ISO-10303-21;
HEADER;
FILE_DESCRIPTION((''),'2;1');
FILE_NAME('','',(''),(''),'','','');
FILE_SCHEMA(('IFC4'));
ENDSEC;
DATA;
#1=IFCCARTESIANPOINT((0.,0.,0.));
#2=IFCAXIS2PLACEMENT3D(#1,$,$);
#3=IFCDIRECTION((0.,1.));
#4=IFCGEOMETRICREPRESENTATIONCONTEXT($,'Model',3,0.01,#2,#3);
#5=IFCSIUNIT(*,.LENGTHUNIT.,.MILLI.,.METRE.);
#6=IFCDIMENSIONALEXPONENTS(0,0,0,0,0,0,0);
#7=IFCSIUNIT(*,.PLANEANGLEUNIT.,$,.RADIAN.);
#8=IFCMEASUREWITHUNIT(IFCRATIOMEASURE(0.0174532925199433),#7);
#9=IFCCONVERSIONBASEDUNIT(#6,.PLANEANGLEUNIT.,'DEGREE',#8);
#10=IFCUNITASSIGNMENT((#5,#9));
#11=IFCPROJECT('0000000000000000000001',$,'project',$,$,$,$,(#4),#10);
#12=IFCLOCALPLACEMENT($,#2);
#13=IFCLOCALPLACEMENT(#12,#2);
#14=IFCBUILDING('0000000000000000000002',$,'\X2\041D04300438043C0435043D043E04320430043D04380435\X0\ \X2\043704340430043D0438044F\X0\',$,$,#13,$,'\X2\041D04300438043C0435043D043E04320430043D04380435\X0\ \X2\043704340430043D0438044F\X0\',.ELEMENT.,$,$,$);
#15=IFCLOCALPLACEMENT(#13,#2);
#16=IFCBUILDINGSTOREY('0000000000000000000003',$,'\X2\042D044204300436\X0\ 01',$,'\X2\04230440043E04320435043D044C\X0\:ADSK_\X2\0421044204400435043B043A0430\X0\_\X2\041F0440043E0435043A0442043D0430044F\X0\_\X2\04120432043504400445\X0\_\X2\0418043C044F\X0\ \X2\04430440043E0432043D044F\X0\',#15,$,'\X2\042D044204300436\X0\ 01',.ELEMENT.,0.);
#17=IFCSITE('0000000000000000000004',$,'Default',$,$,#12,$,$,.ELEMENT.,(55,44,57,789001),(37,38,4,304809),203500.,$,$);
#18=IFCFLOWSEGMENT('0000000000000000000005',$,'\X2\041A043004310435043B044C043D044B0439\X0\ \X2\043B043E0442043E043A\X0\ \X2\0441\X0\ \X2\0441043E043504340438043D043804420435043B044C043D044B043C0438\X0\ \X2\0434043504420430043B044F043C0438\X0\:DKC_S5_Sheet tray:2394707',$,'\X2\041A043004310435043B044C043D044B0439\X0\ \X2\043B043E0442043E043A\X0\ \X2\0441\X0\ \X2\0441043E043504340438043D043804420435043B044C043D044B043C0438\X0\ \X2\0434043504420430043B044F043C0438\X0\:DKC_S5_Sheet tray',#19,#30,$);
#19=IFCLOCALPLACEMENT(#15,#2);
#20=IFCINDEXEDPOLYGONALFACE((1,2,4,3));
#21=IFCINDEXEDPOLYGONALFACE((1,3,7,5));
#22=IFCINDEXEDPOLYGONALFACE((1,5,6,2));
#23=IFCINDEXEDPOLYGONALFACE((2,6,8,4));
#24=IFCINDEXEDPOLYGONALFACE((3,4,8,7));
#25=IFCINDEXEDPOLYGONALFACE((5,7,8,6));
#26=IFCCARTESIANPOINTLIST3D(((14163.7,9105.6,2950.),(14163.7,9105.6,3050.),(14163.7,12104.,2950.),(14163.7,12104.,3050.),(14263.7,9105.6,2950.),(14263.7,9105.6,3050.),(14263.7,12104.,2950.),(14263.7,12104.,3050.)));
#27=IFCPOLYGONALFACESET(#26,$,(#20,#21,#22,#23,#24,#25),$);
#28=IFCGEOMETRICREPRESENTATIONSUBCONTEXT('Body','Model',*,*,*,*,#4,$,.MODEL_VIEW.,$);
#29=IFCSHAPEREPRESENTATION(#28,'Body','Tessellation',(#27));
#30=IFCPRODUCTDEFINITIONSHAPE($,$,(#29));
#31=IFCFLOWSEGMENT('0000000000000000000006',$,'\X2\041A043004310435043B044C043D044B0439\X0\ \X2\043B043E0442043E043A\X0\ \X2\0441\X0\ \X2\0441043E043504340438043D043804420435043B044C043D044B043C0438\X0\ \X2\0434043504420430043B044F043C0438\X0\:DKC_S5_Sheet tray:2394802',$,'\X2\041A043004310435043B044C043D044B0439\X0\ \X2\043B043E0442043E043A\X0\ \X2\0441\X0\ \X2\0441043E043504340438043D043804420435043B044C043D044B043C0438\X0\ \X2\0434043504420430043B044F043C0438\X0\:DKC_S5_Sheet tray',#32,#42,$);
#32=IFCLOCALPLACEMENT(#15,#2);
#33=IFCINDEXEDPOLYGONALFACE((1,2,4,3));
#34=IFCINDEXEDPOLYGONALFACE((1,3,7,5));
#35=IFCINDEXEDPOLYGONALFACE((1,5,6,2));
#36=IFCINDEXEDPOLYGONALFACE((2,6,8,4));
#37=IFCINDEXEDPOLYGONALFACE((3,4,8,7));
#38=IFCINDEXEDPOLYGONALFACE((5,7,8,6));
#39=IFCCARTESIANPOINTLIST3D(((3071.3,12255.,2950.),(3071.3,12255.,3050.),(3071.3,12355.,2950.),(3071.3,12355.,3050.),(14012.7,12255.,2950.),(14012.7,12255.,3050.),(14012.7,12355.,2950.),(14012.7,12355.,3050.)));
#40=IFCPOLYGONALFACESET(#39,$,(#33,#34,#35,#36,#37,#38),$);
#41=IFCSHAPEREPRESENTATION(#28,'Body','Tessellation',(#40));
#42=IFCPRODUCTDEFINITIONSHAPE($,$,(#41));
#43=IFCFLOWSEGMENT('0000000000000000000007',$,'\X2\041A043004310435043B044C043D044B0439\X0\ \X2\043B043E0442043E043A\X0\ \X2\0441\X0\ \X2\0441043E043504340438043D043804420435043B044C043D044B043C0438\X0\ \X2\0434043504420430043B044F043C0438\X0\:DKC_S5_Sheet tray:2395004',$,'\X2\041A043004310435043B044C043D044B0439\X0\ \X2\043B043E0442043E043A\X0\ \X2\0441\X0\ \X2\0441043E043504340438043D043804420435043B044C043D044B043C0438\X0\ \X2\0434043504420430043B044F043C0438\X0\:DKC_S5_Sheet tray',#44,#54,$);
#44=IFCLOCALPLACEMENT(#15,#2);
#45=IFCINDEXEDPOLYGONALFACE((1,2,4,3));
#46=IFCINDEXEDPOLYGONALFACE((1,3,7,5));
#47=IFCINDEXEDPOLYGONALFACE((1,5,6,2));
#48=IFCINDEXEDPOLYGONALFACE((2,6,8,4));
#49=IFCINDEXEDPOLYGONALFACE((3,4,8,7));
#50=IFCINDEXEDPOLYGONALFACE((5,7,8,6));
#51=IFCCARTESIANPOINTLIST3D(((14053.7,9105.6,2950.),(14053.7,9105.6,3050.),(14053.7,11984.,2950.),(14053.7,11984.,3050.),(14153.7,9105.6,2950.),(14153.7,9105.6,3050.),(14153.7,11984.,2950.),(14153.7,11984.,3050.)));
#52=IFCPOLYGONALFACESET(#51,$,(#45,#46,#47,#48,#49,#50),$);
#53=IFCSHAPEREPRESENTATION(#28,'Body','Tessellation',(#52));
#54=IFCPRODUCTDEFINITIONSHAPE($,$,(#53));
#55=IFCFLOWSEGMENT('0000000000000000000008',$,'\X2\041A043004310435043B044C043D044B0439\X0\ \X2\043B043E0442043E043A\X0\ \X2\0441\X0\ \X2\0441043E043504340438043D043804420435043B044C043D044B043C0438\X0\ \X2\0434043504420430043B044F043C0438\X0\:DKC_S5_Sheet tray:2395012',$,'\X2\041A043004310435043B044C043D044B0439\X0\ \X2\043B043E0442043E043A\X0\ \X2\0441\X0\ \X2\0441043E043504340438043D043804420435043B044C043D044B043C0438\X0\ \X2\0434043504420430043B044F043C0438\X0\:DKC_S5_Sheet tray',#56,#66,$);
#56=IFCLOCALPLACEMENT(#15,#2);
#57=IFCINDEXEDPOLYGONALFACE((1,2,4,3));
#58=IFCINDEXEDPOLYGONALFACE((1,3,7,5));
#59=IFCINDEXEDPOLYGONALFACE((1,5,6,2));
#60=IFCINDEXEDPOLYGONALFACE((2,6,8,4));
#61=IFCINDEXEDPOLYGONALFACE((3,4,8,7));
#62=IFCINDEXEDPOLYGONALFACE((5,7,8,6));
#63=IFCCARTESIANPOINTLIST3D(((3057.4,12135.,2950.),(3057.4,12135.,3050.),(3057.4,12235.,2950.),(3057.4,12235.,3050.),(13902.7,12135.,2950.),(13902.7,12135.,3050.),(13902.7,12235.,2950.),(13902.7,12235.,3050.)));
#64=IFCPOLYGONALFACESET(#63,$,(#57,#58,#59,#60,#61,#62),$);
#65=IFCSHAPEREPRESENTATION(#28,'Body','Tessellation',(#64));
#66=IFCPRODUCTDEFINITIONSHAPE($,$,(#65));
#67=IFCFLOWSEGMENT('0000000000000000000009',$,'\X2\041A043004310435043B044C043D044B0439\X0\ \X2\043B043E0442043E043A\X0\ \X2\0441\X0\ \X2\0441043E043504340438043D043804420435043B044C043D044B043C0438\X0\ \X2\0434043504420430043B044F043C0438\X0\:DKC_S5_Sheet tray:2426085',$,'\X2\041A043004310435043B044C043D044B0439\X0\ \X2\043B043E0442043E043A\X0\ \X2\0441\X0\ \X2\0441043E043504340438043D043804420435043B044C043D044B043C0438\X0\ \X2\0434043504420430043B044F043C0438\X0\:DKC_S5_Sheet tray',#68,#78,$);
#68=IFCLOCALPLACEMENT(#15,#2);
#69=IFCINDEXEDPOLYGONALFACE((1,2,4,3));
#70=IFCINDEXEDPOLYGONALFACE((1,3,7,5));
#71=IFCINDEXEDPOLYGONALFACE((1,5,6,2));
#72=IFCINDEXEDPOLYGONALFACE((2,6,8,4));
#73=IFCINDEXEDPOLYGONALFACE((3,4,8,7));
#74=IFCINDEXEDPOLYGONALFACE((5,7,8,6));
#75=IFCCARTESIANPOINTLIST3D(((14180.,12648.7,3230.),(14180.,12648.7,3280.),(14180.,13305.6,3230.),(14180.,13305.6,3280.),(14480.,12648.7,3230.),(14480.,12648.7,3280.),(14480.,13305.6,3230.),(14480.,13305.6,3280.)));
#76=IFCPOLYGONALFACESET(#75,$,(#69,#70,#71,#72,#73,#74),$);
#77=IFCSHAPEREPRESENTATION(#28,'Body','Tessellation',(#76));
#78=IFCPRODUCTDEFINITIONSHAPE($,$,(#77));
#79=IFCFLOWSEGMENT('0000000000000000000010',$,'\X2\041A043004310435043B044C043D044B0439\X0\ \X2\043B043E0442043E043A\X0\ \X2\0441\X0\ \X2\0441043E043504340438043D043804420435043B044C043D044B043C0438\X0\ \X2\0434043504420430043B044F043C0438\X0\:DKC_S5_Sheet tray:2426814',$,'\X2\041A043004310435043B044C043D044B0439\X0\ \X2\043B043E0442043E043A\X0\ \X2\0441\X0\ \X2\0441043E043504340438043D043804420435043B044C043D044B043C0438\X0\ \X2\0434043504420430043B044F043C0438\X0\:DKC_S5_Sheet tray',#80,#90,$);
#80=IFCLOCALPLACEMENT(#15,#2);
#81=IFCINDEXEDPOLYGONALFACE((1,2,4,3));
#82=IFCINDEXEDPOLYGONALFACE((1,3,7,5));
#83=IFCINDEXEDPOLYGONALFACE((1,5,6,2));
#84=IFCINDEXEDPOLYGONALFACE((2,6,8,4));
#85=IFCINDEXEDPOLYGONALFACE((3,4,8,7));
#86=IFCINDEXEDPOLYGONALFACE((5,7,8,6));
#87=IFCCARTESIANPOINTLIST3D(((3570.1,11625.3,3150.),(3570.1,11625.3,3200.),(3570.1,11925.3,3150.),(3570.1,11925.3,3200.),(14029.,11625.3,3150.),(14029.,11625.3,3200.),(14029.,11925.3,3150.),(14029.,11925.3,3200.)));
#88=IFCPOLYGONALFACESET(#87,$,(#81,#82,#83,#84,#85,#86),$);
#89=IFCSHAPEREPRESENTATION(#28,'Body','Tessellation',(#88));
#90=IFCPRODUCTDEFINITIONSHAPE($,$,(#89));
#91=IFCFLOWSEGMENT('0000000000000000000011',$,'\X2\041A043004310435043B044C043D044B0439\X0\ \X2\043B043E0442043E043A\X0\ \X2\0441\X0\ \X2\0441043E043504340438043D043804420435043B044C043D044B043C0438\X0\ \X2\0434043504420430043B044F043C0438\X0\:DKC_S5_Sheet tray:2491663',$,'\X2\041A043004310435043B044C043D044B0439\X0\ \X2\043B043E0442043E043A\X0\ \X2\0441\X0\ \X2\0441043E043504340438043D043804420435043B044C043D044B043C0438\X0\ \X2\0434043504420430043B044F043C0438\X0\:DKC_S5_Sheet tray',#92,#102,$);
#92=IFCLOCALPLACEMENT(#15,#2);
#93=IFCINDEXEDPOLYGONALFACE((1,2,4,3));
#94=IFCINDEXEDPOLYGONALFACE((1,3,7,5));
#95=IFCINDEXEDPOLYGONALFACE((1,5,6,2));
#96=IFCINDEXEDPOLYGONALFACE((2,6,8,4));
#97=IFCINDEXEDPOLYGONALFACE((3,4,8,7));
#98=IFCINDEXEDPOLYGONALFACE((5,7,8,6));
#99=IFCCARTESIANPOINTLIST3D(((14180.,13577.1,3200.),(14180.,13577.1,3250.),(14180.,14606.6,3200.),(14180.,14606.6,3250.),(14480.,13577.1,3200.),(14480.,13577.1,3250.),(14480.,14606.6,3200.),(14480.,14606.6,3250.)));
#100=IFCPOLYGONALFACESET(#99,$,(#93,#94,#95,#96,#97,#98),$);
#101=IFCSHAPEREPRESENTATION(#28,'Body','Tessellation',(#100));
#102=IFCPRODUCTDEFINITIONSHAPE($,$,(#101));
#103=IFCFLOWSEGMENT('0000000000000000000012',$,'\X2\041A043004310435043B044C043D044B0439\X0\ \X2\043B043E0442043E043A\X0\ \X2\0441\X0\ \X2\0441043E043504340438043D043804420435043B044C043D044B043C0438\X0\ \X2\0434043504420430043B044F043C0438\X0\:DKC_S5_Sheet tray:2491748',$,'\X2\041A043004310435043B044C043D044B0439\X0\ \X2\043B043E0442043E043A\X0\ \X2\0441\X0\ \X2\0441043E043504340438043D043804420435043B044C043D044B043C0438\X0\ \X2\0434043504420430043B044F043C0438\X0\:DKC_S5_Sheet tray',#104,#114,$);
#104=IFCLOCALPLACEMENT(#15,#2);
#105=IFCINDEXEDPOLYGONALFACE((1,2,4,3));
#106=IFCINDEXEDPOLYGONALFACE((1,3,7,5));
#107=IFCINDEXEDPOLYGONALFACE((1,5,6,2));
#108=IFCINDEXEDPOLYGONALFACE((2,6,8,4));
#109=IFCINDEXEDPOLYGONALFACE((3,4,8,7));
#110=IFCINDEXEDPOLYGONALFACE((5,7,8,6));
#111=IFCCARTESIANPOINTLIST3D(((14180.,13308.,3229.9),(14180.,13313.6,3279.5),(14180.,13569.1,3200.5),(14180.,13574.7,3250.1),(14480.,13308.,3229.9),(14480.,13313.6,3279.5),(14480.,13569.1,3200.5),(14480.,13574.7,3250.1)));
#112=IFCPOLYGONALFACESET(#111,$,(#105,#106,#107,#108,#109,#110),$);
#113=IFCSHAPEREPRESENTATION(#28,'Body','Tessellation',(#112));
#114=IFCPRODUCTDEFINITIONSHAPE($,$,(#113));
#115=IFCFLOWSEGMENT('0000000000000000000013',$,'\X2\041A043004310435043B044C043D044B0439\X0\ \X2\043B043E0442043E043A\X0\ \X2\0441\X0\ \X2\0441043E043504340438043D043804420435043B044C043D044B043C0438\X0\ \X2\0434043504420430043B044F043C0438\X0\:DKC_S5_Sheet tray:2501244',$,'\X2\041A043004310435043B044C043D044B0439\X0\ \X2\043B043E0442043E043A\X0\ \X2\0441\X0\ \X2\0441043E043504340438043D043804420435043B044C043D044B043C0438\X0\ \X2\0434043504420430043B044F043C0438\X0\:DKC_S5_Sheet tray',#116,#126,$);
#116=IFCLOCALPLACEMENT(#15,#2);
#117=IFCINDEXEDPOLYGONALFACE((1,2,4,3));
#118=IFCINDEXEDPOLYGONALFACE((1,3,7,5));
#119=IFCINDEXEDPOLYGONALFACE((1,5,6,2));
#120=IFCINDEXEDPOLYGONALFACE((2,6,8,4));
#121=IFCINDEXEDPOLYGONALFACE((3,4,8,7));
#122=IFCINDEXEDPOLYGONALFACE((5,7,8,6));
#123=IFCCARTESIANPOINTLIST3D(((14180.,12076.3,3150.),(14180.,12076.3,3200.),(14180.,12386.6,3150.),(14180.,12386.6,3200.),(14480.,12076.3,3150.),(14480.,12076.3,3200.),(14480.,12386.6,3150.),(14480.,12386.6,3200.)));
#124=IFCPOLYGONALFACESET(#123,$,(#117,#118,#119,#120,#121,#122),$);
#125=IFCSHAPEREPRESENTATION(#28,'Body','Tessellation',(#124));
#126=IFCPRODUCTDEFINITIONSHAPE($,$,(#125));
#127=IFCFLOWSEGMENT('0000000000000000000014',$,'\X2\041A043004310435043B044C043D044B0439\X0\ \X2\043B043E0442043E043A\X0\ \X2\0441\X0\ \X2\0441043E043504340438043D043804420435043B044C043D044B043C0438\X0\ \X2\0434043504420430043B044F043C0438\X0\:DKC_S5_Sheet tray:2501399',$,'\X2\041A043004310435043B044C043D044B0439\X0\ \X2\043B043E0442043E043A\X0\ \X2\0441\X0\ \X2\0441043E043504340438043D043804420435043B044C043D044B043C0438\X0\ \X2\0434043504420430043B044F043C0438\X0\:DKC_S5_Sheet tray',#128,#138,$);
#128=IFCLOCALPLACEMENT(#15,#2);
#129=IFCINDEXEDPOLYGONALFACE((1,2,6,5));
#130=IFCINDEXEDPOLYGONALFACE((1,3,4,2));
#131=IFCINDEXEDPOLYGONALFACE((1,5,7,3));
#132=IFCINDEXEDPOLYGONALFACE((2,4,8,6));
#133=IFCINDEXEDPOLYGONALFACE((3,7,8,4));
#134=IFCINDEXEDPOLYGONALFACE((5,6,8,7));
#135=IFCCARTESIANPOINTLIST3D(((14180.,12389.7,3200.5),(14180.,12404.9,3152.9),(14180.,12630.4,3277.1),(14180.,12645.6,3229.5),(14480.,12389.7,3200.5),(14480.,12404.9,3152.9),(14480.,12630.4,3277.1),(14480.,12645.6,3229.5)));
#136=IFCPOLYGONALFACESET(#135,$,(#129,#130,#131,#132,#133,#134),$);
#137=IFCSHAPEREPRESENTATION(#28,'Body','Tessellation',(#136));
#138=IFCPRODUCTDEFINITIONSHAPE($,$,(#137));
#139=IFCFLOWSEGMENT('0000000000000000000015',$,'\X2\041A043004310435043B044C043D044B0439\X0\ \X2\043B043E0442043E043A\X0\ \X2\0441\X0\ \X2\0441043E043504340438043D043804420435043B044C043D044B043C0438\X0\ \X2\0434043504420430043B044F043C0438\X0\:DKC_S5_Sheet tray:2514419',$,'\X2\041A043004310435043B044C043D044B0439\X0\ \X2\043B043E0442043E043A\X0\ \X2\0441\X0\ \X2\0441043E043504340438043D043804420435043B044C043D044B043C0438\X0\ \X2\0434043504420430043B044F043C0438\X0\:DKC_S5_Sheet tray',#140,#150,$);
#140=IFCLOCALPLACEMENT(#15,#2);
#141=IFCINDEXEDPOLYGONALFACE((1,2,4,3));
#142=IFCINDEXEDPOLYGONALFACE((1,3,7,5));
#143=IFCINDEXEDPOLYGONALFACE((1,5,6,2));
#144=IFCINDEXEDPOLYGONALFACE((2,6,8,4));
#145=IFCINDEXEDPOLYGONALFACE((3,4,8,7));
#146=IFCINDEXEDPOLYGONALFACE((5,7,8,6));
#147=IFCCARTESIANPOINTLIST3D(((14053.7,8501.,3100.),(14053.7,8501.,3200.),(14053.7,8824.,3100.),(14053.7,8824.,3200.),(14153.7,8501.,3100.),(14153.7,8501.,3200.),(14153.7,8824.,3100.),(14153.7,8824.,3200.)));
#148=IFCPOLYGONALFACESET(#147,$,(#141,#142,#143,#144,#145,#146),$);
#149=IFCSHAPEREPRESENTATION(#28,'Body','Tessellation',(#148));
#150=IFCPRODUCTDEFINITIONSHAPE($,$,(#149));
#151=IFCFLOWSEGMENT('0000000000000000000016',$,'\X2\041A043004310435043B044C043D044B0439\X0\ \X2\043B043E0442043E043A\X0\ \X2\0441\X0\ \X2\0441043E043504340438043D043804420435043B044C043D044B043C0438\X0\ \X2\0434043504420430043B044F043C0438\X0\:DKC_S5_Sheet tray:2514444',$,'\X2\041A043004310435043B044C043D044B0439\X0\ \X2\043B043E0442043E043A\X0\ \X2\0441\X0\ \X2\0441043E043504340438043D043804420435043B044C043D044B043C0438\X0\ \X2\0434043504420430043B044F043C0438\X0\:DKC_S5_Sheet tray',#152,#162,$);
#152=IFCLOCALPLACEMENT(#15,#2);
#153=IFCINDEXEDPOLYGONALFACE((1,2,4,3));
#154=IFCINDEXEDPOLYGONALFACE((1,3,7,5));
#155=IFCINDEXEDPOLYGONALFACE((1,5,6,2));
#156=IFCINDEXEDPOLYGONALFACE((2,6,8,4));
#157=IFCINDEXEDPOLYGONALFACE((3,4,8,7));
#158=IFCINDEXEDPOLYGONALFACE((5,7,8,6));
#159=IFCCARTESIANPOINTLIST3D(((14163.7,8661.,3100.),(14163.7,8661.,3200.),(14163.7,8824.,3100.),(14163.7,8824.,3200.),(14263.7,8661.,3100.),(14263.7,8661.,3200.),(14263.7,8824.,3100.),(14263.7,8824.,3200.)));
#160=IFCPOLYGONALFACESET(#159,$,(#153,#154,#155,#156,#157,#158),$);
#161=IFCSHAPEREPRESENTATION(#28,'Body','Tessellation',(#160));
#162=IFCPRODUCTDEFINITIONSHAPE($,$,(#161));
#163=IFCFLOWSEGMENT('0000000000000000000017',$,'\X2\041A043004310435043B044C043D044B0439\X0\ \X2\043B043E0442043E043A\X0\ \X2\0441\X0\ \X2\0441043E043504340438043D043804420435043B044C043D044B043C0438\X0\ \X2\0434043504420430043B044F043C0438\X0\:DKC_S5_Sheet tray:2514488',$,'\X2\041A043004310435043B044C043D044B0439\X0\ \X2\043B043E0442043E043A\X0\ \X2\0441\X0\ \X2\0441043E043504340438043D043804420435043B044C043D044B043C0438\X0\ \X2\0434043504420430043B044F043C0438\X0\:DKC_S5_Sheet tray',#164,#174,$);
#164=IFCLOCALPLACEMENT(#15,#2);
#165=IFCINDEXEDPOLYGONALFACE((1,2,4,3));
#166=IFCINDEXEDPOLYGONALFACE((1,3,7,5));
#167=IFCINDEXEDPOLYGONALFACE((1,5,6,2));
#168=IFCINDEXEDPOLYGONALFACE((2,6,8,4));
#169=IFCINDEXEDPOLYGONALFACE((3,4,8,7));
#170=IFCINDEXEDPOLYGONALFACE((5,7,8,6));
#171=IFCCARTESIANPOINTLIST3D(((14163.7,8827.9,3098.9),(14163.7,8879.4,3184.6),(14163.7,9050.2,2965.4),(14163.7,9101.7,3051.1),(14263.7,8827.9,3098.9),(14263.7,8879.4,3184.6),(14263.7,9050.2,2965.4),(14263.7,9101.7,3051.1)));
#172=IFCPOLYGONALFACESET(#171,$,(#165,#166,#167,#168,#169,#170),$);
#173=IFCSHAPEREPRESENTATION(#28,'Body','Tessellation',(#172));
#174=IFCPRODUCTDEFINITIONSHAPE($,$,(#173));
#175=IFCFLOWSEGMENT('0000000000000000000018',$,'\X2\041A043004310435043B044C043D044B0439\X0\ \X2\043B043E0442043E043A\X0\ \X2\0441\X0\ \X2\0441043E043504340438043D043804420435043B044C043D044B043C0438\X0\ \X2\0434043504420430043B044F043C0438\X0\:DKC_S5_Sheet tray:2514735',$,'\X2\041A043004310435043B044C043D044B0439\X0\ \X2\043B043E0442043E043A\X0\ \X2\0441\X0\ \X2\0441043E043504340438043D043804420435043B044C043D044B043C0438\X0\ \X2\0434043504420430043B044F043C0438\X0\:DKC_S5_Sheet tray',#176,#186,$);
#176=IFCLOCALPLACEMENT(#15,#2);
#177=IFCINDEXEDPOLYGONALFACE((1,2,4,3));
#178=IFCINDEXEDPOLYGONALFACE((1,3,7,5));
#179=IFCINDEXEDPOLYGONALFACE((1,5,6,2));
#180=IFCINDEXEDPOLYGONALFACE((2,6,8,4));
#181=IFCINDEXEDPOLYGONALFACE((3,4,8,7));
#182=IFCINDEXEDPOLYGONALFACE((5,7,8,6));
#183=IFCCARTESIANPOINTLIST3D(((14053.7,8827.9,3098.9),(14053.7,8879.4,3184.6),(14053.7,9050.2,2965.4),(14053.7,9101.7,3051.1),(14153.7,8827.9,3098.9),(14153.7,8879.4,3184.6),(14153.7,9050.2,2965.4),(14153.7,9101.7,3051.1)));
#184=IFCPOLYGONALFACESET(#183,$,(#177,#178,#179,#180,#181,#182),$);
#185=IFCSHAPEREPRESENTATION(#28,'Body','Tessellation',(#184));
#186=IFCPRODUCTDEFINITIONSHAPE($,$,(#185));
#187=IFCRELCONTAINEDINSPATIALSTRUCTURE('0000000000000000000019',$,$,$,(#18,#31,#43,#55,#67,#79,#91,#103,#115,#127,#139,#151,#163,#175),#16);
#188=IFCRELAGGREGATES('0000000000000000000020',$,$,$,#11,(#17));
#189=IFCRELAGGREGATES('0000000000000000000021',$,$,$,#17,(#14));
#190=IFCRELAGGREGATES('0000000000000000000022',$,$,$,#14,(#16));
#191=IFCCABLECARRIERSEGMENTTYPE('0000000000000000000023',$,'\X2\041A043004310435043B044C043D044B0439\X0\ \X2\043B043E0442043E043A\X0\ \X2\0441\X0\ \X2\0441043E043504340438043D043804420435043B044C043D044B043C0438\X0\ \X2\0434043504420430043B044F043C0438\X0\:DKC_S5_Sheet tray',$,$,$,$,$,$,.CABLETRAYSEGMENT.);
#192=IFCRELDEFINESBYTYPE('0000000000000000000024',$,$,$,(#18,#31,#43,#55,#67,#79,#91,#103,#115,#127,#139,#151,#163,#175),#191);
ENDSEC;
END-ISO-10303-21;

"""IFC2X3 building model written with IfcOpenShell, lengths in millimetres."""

from ifc_helpers import new_model, entity, si_unit, converted_unit, direction, frame, frame_2d, origin, origin_2d_with_axis, place, context, subcontext, project, spatial, rectangle, extrude, type_object, element, save


model = new_model("IFC2X3")

# Units and contexts
model_context = context("Model", 3, precision=0.01, world=origin(), true_north=direction((0.0, 1.0)))
body_context = subcontext(model_context, "Body", "Model", "MODEL_VIEW")
ifc_project = project(units=[si_unit("LENGTHUNIT", "METRE", prefix="MILLI"), converted_unit("PLANEANGLEUNIT", "DEGREE", entity("IfcRatioMeasure", 0.0174532925199433), si_unit("PLANEANGLEUNIT", "RADIAN"), dimensions=[0, 0, 0, 0, 0, 0, 0])], contexts=[model_context])

# Site, building, storey
site_placement = place(None, origin())
site = spatial("IfcSite", under=ifc_project, at=site_placement, Name="Default", CompositionType="ELEMENT", RefLatitude=(55, 44, 57, 789001), RefLongitude=(37, 38, 4, 304809), RefElevation=203500.0)
building_placement = place(site_placement, origin())
building = spatial("IfcBuilding", under=site, at=building_placement, Name="Наименование здания", LongName="Наименование здания", CompositionType="ELEMENT")
storey_placement = place(building_placement, origin())
storey = spatial("IfcBuildingStorey", under=building, at=storey_placement, Name="Этаж 01", ObjectType="Уровень:ADSK_Стрелка_Проектная_Вверх_Имя уровня", LongName="Этаж 01", CompositionType="ELEMENT", Elevation=0.0)

# Flow segments
cable_carrier_segment_type = type_object("IfcCableCarrierSegmentType", Name="Кабельный лоток с соединительными деталями:DKC_S5_Sheet tray", PredefinedType="CABLETRAYSEGMENT")
flow_segment_1_placement = place(storey_placement, frame((14163.7, 9105.6, 2950.0)))
element("IfcFlowSegment", 1, at=flow_segment_1_placement, inside=storey, type_object=cable_carrier_segment_type, Name="Кабельный лоток с соединительными деталями:DKC_S5_Sheet tray:2394707", ObjectType="Кабельный лоток с соединительными деталями:DKC_S5_Sheet tray", context=body_context, shape_type="SweptSolid", body=[
    extrude(rectangle(XDim=2998.4, YDim=100.0, at=origin_2d_with_axis()), frame((50.0, 1499.2, 0.0), z_axis=(0.0, 0.0, 1.0), x_axis=(0.0, -1.0, 0.0)), (0.0, 0.0, 1.0), 100.0),
])
flow_segment_2_placement = place(storey_placement, frame((3071.3, 12255.0, 2950.0)))
element("IfcFlowSegment", 2, at=flow_segment_2_placement, inside=storey, type_object=cable_carrier_segment_type, Name="Кабельный лоток с соединительными деталями:DKC_S5_Sheet tray:2394802", ObjectType="Кабельный лоток с соединительными деталями:DKC_S5_Sheet tray", context=body_context, shape_type="SweptSolid", body=[
    extrude(rectangle(XDim=10941.4, YDim=100.0, at=origin_2d_with_axis()), frame((5470.7, 50.0, 0.0), z_axis=(0.0, 0.0, 1.0), x_axis=(-1.0, 0.0, 0.0)), (0.0, 0.0, 1.0), 100.0),
])
flow_segment_3_placement = place(storey_placement, frame((14053.7, 9105.6, 2950.0)))
element("IfcFlowSegment", 3, at=flow_segment_3_placement, inside=storey, type_object=cable_carrier_segment_type, Name="Кабельный лоток с соединительными деталями:DKC_S5_Sheet tray:2395004", ObjectType="Кабельный лоток с соединительными деталями:DKC_S5_Sheet tray", context=body_context, shape_type="SweptSolid", body=[
    extrude(rectangle(XDim=2878.4, YDim=100.0, at=origin_2d_with_axis()), frame((50.0, 1439.2, 0.0), z_axis=(0.0, 0.0, 1.0), x_axis=(0.0, -1.0, 0.0)), (0.0, 0.0, 1.0), 100.0),
])
flow_segment_4_placement = place(storey_placement, frame((3057.4, 12135.0, 2950.0)))
element("IfcFlowSegment", 4, at=flow_segment_4_placement, inside=storey, type_object=cable_carrier_segment_type, Name="Кабельный лоток с соединительными деталями:DKC_S5_Sheet tray:2395012", ObjectType="Кабельный лоток с соединительными деталями:DKC_S5_Sheet tray", context=body_context, shape_type="SweptSolid", body=[
    extrude(rectangle(XDim=10845.3, YDim=100.0, at=origin_2d_with_axis()), frame((5422.6, 50.0, 0.0), z_axis=(0.0, 0.0, 1.0), x_axis=(-1.0, 0.0, 0.0)), (0.0, 0.0, 1.0), 100.0),
])
flow_segment_5_placement = place(storey_placement, frame((14180.0, 12648.7, 3230.0)))
element("IfcFlowSegment", 5, at=flow_segment_5_placement, inside=storey, type_object=cable_carrier_segment_type, Name="Кабельный лоток с соединительными деталями:DKC_S5_Sheet tray:2426085", ObjectType="Кабельный лоток с соединительными деталями:DKC_S5_Sheet tray", context=body_context, shape_type="SweptSolid", body=[
    extrude(rectangle(XDim=656.9, YDim=300.0, at=origin_2d_with_axis()), frame((150.0, 328.4, 0.0), z_axis=(0.0, 0.0, 1.0), x_axis=(0.0, -1.0, 0.0)), (0.0, 0.0, 1.0), 50.0),
])
flow_segment_6_placement = place(storey_placement, frame((3570.1, 11625.3, 3150.0)))
element("IfcFlowSegment", 6, at=flow_segment_6_placement, inside=storey, type_object=cable_carrier_segment_type, Name="Кабельный лоток с соединительными деталями:DKC_S5_Sheet tray:2426814", ObjectType="Кабельный лоток с соединительными деталями:DKC_S5_Sheet tray", context=body_context, shape_type="SweptSolid", body=[
    extrude(rectangle(XDim=10458.9, YDim=300.0, at=origin_2d_with_axis()), frame((5229.4, 150.0, 0.0), z_axis=(0.0, 0.0, 1.0), x_axis=(-1.0, 0.0, 0.0)), (0.0, 0.0, 1.0), 50.0),
])
flow_segment_7_placement = place(storey_placement, frame((14180.0, 13577.1, 3200.0)))
element("IfcFlowSegment", 7, at=flow_segment_7_placement, inside=storey, type_object=cable_carrier_segment_type, Name="Кабельный лоток с соединительными деталями:DKC_S5_Sheet tray:2491663", ObjectType="Кабельный лоток с соединительными деталями:DKC_S5_Sheet tray", context=body_context, shape_type="SweptSolid", body=[
    extrude(rectangle(XDim=1029.5, YDim=300.0, at=origin_2d_with_axis()), frame((150.0, 514.7, 0.0), z_axis=(0.0, 0.0, 1.0), x_axis=(0.0, -1.0, 0.0)), (0.0, 0.0, 1.0), 50.0),
])
flow_segment_8_placement = place(storey_placement, frame((14180.0, 13308.0, 3200.4)))
element("IfcFlowSegment", 8, at=flow_segment_8_placement, inside=storey, type_object=cable_carrier_segment_type, Name="Кабельный лоток с соединительными деталями:DKC_S5_Sheet tray:2491748", ObjectType="Кабельный лоток с соединительными деталями:DKC_S5_Sheet tray", context=body_context, shape_type="SweptSolid", body=[
    extrude(rectangle(XDim=50.0, YDim=262.7, at=frame_2d((0.0, 0.0), x_axis=(0.0, 1.0))), frame((0.0, 133.3, 39.5), z_axis=(1.0, 0.0, 0.0), x_axis=(0.0, 0.993713, -0.111959)), (0.0, 0.0, 1.0), 300.0),
])
flow_segment_9_placement = place(storey_placement, frame((14180.0, 12076.3, 3150.0)))
element("IfcFlowSegment", 9, at=flow_segment_9_placement, inside=storey, type_object=cable_carrier_segment_type, Name="Кабельный лоток с соединительными деталями:DKC_S5_Sheet tray:2501244", ObjectType="Кабельный лоток с соединительными деталями:DKC_S5_Sheet tray", context=body_context, shape_type="SweptSolid", body=[
    extrude(rectangle(XDim=310.3, YDim=300.0, at=origin_2d_with_axis()), frame((150.0, 155.2, 0.0), z_axis=(0.0, 0.0, 1.0), x_axis=(0.0, 1.0, 0.0)), (0.0, 0.0, 1.0), 50.0),
])
flow_segment_10_placement = place(storey_placement, frame((14180.0, 12389.7, 3152.8)))
element("IfcFlowSegment", 10, at=flow_segment_10_placement, inside=storey, type_object=cable_carrier_segment_type, Name="Кабельный лоток с соединительными деталями:DKC_S5_Sheet tray:2501399", ObjectType="Кабельный лоток с соединительными деталями:DKC_S5_Sheet tray", context=body_context, shape_type="SweptSolid", body=[
    extrude(rectangle(XDim=50.0, YDim=252.6, at=frame_2d((0.0, 0.0), x_axis=(0.0, 1.0))), frame((0.0, 127.9, 62.1), z_axis=(1.0, 0.0, 0.0), x_axis=(0.0, -0.952827, -0.303512)), (0.0, 0.0, 1.0), 300.0),
])
flow_segment_11_placement = place(storey_placement, frame((14053.7, 8501.0, 3100.0)))
element("IfcFlowSegment", 11, at=flow_segment_11_placement, inside=storey, type_object=cable_carrier_segment_type, Name="Кабельный лоток с соединительными деталями:DKC_S5_Sheet tray:2514419", ObjectType="Кабельный лоток с соединительными деталями:DKC_S5_Sheet tray", context=body_context, shape_type="SweptSolid", body=[
    extrude(rectangle(XDim=323.0, YDim=100.0, at=origin_2d_with_axis()), frame((50.0, 161.5, 0.0), z_axis=(0.0, 0.0, 1.0), x_axis=(0.0, 1.0, 0.0)), (0.0, 0.0, 1.0), 100.0),
])
flow_segment_12_placement = place(storey_placement, frame((14163.7, 8661.0, 3100.0)))
element("IfcFlowSegment", 12, at=flow_segment_12_placement, inside=storey, type_object=cable_carrier_segment_type, Name="Кабельный лоток с соединительными деталями:DKC_S5_Sheet tray:2514444", ObjectType="Кабельный лоток с соединительными деталями:DKC_S5_Sheet tray", context=body_context, shape_type="SweptSolid", body=[
    extrude(rectangle(XDim=163.0, YDim=100.0, at=origin_2d_with_axis()), frame((50.0, 81.5, 0.0), z_axis=(0.0, 0.0, 1.0), x_axis=(0.0, 1.0, 0.0)), (0.0, 0.0, 1.0), 100.0),
])
flow_segment_13_placement = place(storey_placement, frame((14163.7, 8827.9, 2965.4)))
element("IfcFlowSegment", 13, at=flow_segment_13_placement, inside=storey, type_object=cable_carrier_segment_type, Name="Кабельный лоток с соединительными деталями:DKC_S5_Sheet tray:2514488", ObjectType="Кабельный лоток с соединительными деталями:DKC_S5_Sheet tray", context=body_context, shape_type="SweptSolid", body=[
    extrude(rectangle(XDim=100.0, YDim=100.0, at=frame_2d((0.0, 0.0), x_axis=(0.0, 1.0))), frame((50.0, 25.8, 176.4), z_axis=(0.0, 0.857167, -0.515038), x_axis=(-1.0, 0.0, 0.0)), (0.0, 0.0, 1.0), 259.3),
])
flow_segment_14_placement = place(storey_placement, frame((14053.7, 8827.9, 2965.4)))
element("IfcFlowSegment", 14, at=flow_segment_14_placement, inside=storey, type_object=cable_carrier_segment_type, Name="Кабельный лоток с соединительными деталями:DKC_S5_Sheet tray:2514735", ObjectType="Кабельный лоток с соединительными деталями:DKC_S5_Sheet tray", context=body_context, shape_type="SweptSolid", body=[
    extrude(rectangle(XDim=100.0, YDim=100.0, at=frame_2d((0.0, 0.0), x_axis=(0.0, 1.0))), frame((50.0, 25.8, 176.4), z_axis=(0.0, 0.857167, -0.515038), x_axis=(-1.0, 0.0, 0.0)), (0.0, 0.0, 1.0), 259.3),
])

save(model, "model.ifc")
